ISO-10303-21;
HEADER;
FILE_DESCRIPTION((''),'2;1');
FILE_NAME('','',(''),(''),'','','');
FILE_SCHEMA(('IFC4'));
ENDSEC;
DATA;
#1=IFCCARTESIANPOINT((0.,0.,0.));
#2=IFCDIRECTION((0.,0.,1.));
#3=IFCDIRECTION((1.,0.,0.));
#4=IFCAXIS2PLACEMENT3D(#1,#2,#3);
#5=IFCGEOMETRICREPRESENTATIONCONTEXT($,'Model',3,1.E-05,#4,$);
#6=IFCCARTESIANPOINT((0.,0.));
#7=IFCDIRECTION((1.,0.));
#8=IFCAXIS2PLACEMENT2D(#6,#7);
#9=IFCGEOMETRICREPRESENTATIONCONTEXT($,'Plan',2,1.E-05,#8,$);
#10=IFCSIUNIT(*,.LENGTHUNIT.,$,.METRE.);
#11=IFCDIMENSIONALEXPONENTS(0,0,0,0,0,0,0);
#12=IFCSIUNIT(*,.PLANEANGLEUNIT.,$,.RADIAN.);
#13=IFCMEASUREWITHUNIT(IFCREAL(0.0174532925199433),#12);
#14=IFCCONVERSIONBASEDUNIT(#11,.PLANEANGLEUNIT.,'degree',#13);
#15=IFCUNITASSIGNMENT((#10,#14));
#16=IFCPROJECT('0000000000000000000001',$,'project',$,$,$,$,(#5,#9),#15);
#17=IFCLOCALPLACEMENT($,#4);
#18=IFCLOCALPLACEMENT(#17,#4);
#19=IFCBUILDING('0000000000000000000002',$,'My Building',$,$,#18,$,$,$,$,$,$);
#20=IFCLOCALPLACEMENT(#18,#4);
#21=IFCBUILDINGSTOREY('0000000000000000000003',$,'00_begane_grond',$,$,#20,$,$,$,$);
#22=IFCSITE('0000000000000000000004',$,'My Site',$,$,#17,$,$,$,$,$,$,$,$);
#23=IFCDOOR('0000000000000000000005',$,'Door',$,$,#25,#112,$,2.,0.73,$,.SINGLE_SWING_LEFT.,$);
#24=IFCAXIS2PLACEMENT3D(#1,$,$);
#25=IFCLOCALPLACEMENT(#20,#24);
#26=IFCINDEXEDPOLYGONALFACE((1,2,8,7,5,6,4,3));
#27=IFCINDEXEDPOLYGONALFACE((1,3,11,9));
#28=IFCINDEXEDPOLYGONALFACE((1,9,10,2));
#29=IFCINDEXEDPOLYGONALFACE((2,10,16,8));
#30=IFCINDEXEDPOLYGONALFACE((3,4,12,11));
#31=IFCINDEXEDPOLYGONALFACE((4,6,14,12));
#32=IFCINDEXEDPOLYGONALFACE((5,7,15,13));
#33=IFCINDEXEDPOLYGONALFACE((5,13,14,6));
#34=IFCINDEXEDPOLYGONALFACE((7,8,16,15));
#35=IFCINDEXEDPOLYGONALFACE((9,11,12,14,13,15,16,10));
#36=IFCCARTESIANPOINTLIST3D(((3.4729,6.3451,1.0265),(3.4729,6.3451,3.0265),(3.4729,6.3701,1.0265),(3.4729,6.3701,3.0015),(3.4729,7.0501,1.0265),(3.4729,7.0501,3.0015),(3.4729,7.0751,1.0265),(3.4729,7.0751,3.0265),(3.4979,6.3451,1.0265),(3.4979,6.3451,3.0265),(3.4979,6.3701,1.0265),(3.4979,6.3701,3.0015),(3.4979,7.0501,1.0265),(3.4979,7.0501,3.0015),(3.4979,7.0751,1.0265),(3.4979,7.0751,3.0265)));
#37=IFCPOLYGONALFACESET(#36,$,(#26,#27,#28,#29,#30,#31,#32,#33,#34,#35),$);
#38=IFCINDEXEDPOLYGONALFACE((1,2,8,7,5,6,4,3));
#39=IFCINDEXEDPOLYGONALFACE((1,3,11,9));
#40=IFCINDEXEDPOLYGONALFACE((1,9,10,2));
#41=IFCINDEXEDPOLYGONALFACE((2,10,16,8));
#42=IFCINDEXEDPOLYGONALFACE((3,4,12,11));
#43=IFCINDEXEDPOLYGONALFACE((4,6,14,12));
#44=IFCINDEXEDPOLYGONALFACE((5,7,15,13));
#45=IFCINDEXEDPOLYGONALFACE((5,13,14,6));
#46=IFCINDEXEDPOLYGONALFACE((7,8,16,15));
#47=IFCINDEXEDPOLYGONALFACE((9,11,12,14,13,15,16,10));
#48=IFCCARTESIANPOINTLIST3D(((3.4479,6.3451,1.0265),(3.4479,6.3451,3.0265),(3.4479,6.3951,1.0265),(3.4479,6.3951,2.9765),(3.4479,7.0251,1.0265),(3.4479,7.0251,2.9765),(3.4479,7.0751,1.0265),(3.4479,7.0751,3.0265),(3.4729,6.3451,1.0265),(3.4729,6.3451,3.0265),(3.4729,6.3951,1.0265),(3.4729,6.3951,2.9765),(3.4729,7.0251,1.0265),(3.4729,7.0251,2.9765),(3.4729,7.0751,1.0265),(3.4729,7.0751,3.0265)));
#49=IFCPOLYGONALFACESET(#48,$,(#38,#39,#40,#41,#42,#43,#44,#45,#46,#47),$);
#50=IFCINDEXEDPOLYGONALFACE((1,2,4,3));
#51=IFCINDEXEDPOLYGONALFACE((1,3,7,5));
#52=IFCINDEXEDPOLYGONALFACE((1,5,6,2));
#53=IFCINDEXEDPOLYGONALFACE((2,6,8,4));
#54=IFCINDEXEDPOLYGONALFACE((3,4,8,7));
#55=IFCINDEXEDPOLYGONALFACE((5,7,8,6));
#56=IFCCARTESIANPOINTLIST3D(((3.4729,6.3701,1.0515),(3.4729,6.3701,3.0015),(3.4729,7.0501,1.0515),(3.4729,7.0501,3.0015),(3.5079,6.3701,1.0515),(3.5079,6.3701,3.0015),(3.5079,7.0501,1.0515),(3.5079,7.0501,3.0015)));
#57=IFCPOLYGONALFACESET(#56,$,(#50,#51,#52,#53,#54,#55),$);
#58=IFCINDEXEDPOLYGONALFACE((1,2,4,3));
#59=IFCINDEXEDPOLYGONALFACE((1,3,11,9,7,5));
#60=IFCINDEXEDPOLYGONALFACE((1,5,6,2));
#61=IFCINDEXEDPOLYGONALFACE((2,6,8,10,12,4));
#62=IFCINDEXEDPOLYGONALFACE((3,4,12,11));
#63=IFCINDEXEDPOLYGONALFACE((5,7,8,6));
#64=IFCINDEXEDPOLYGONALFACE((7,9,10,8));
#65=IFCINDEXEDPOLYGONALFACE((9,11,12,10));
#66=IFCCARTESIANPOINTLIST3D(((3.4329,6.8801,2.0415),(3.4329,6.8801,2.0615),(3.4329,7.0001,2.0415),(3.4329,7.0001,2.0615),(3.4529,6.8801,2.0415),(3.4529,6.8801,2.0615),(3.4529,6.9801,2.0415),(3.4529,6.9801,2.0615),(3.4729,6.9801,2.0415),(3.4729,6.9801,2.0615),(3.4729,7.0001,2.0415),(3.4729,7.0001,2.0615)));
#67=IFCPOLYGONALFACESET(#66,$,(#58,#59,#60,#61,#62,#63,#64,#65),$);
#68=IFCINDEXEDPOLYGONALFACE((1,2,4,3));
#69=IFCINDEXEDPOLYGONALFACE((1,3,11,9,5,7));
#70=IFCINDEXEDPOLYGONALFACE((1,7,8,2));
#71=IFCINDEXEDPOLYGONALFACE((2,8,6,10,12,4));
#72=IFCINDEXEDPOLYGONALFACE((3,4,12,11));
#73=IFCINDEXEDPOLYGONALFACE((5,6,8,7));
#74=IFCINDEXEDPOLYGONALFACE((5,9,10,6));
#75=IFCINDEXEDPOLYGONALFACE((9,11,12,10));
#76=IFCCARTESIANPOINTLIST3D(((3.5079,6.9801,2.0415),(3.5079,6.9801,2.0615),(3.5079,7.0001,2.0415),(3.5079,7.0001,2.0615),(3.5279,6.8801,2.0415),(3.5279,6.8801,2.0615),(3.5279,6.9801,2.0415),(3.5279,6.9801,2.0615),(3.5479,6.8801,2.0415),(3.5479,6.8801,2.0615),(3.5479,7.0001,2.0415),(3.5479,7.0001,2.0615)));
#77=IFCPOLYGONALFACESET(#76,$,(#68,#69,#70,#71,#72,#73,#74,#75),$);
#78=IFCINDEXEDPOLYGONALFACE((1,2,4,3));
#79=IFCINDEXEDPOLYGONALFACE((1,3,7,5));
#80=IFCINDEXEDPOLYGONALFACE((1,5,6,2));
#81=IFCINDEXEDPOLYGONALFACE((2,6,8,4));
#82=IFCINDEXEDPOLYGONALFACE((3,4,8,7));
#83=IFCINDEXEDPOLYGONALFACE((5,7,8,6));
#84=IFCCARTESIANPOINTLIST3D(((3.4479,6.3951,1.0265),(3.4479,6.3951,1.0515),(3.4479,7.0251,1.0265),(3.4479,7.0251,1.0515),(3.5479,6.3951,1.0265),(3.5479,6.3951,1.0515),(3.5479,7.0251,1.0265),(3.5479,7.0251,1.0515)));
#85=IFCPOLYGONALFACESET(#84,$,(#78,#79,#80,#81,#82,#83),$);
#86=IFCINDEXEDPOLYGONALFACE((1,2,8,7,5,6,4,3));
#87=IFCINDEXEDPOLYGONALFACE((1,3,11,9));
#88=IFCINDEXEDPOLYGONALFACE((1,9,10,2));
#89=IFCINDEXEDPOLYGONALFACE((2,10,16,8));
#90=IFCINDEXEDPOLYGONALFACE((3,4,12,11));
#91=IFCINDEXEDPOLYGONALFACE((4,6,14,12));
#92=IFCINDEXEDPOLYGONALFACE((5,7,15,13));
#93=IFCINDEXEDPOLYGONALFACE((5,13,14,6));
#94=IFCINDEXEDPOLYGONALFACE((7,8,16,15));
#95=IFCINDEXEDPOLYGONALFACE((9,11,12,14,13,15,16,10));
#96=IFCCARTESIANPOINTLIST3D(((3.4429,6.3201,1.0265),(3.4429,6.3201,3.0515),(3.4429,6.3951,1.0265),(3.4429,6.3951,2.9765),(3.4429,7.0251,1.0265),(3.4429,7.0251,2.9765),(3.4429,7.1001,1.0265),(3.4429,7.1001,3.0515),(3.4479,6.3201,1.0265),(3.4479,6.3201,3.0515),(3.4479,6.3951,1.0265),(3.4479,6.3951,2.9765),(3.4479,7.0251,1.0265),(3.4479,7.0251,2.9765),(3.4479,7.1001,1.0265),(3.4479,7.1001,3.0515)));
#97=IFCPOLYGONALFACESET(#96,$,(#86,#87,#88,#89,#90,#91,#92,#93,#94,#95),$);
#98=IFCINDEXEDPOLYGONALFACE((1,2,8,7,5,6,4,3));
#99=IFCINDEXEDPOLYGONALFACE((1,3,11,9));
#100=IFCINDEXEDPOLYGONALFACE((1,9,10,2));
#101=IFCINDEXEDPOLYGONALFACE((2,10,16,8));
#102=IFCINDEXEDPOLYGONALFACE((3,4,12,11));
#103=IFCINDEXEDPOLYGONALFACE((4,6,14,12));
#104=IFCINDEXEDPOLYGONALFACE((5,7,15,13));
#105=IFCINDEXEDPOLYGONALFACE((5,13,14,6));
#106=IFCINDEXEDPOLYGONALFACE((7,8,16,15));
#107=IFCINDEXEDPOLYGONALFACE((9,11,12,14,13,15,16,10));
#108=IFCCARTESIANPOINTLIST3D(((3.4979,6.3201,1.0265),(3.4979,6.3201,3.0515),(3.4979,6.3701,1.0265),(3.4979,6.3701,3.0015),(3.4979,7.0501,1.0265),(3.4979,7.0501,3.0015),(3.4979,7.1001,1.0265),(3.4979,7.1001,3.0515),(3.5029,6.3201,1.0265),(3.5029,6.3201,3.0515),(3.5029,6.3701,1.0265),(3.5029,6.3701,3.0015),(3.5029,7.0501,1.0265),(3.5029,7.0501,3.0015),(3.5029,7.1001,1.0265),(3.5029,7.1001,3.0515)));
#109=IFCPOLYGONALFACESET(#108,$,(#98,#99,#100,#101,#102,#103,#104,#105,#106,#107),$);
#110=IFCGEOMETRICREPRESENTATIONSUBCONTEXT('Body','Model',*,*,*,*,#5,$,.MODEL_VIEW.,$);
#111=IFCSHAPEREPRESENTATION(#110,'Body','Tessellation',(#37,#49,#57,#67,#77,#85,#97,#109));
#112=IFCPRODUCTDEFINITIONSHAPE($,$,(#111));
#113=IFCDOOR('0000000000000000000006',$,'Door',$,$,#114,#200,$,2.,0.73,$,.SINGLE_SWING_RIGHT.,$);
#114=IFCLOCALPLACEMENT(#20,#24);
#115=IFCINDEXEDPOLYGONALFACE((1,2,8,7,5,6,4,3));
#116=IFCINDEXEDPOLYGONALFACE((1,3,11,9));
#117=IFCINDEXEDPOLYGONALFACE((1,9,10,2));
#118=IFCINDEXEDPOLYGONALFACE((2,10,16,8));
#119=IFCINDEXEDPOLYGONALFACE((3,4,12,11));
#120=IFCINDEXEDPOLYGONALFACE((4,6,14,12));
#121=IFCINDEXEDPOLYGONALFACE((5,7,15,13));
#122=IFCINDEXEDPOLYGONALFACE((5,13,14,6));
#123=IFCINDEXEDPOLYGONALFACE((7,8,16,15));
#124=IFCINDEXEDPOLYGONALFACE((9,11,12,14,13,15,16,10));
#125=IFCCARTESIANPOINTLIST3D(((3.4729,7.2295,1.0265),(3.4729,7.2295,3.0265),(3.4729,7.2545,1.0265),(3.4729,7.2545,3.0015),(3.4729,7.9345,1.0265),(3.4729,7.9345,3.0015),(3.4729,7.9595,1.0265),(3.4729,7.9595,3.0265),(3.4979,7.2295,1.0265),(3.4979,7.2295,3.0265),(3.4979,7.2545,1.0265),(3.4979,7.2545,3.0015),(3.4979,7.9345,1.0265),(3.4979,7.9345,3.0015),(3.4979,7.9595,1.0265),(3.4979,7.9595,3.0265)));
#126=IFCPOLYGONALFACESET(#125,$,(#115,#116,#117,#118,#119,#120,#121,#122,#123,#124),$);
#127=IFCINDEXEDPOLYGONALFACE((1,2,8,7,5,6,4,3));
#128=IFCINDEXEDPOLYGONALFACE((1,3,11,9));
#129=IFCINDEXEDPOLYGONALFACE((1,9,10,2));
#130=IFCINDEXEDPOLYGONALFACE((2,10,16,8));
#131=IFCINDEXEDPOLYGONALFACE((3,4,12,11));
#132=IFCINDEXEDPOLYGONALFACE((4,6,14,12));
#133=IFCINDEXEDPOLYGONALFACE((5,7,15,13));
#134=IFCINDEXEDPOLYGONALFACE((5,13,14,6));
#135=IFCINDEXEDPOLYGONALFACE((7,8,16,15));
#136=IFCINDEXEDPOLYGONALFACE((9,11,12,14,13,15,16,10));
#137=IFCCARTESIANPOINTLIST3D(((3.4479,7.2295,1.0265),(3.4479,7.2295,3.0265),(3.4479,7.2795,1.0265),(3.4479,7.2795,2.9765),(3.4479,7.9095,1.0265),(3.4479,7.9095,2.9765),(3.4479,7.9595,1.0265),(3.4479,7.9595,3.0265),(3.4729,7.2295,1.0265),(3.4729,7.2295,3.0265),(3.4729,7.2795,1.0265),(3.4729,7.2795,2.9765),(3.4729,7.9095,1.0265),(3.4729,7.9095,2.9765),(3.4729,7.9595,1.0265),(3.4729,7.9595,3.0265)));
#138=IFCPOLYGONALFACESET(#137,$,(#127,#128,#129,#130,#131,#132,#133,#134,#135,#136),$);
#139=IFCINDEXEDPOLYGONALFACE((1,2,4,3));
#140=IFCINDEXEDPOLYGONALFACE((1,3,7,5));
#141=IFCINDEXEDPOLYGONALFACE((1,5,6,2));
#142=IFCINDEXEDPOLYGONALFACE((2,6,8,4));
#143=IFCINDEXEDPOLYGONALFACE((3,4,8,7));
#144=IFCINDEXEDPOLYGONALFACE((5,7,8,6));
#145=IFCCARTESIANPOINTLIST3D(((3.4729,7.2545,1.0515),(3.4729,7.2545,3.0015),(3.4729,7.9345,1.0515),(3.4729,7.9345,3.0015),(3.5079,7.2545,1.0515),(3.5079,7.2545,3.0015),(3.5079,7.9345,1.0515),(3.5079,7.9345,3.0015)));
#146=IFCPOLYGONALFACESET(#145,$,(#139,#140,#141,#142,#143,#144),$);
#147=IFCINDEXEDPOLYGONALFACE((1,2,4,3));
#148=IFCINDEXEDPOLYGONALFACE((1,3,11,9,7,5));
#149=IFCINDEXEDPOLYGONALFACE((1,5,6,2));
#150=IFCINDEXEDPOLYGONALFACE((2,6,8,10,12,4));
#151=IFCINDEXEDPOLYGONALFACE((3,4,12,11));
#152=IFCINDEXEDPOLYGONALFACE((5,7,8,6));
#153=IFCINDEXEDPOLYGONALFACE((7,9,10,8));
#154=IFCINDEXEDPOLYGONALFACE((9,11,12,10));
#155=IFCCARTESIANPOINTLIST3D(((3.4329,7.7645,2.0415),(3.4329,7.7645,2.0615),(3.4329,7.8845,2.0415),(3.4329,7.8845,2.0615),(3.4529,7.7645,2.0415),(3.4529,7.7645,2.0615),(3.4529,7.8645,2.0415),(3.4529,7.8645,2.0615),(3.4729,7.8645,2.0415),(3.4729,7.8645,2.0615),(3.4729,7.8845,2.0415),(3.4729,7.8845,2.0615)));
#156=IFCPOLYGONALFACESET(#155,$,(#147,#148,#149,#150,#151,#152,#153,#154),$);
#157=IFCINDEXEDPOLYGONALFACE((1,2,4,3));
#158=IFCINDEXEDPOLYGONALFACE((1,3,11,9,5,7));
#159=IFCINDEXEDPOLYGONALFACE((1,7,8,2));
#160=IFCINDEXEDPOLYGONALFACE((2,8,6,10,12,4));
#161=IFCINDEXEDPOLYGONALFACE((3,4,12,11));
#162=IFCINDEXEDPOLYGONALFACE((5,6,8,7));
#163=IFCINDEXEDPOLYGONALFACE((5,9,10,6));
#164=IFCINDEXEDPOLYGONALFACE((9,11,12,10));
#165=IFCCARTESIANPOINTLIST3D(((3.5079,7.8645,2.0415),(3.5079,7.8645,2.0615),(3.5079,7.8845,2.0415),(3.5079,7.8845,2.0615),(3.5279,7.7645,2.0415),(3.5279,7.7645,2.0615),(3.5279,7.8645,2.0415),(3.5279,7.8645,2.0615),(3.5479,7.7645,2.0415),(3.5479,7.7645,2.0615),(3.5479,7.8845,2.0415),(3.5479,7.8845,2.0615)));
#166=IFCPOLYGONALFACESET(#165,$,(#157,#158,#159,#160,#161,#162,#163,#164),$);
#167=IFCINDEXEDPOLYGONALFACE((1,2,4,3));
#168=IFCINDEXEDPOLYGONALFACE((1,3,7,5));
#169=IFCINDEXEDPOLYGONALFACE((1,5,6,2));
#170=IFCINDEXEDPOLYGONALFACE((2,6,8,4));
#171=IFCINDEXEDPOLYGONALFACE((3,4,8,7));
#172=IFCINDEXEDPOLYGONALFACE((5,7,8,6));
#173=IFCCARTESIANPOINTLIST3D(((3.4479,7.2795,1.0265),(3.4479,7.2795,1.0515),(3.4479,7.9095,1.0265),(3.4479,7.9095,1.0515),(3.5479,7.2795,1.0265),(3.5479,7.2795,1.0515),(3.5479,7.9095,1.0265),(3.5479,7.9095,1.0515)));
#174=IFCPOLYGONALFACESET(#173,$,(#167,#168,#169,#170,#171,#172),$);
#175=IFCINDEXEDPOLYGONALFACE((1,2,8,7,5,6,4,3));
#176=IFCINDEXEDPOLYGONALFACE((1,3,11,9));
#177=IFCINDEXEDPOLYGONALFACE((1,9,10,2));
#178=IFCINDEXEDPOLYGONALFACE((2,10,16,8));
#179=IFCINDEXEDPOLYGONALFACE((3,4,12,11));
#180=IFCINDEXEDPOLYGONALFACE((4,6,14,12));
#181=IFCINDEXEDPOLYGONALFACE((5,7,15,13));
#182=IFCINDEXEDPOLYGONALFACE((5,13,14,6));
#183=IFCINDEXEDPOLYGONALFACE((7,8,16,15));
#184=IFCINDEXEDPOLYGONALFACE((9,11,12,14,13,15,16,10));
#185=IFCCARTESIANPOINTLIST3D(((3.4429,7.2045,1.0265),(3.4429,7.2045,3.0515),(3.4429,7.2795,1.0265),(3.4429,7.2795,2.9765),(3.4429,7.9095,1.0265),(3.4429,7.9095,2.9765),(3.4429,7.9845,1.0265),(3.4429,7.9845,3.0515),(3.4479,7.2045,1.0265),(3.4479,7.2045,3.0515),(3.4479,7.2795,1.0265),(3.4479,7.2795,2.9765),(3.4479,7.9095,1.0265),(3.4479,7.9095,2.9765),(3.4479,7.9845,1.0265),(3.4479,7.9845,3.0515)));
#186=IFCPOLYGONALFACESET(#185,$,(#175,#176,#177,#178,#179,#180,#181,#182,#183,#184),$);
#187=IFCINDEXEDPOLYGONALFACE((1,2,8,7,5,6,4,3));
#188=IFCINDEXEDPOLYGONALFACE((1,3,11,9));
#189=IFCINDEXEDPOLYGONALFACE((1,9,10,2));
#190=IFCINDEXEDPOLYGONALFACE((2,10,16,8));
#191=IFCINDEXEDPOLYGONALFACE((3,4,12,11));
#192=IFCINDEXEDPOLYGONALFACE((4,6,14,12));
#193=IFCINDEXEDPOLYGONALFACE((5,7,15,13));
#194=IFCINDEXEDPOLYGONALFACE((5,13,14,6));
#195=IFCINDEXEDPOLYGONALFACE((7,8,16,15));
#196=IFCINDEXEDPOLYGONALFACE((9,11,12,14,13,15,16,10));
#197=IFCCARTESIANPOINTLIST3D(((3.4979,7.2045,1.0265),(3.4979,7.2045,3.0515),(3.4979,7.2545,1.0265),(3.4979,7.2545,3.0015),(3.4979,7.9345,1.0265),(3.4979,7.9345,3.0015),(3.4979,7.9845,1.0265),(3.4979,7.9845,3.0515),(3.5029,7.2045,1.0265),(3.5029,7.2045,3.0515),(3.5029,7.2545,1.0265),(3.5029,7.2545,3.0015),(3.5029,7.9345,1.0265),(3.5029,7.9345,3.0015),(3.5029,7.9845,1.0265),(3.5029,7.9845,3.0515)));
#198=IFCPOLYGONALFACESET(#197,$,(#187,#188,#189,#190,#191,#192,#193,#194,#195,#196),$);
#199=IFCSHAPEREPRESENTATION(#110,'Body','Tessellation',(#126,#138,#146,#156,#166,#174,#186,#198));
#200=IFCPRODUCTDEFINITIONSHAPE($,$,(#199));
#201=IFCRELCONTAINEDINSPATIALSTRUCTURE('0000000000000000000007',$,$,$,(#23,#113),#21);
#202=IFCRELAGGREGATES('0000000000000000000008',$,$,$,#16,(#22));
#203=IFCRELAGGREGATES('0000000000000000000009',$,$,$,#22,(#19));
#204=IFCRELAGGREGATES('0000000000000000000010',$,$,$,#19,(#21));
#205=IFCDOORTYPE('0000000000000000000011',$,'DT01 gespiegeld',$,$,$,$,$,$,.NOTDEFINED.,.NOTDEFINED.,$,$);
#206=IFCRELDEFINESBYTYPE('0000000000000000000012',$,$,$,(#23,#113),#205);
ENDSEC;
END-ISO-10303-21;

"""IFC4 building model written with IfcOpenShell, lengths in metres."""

from ifc_helpers import new_model, entity, si_unit, converted_unit, frame, origin_with_axes, origin_2d_with_axis, place, context, subcontext, project, spatial, line, indexed_curve, outline, extrude, shape, source, transform, mapped, type_object, type_shapes, element, save


model = new_model("IFC4")

# Units and contexts
model_context = context("Model", 3, precision=1e-05, world=origin_with_axes())
plan_context = context("Plan", 2, precision=1e-05, world=origin_2d_with_axis())
body_context_1 = subcontext(model_context, "Body", "Model", "MODEL_VIEW")
body_context_2 = subcontext(plan_context, "Body", "Plan", "PLAN_VIEW")
ifc_project = project(units=[si_unit("LENGTHUNIT", "METRE"), converted_unit("PLANEANGLEUNIT", "degree", entity("IfcReal", 0.0174532925199433), si_unit("PLANEANGLEUNIT", "RADIAN"), dimensions=[0, 0, 0, 0, 0, 0, 0])], contexts=[model_context, plan_context])

# Site, building, storey
site_placement = place(None, origin_with_axes())
site = spatial("IfcSite", under=ifc_project, at=site_placement, Name="My Site")
building_placement = place(site_placement, origin_with_axes())
building = spatial("IfcBuilding", under=site, at=building_placement, Name="My Building")
storey_placement = place(building_placement, origin_with_axes())
storey = spatial("IfcBuildingStorey", under=building, at=storey_placement, Name="00_begane_grond")

# Doors
door_type_1 = type_object("IfcDoorType", Name="DT01 gespiegeld", OperationType="NOTDEFINED", PredefinedType="NOTDEFINED")
shared_shape_1 = source(origin_with_axes(), body_context_1, "Body", "SweptSolid", [
    extrude(outline(indexed_curve([(0.0, 0.0), (0.0, 2.0), (0.73, 2.0), (0.73, 0.0), (0.705, 0.0), (0.705, 1.975), (0.025, 1.975), (0.025, 0.0)], segments=[line(1, 2, 3, 4, 5, 6, 7, 8, 1)])), frame((0.0, 0.025, 0.0), z_axis=(0.0, -1.0, 0.0), x_axis=(1.0, 0.0, 0.0)), (0.0, 0.0, -1.0), 0.025),
    extrude(outline(indexed_curve([(0.0, 0.0), (0.0, 2.0), (0.73, 2.0), (0.73, 0.0), (0.68, 0.0), (0.68, 1.95), (0.05, 1.95), (0.05, 0.0)], segments=[line(1, 2, 3, 4, 5, 6, 7, 8, 1)])), frame((0.0, 0.0, 0.0), z_axis=(0.0, -1.0, 0.0), x_axis=(1.0, 0.0, 0.0)), (0.0, 0.0, -1.0), 0.025),
    extrude(outline(indexed_curve([(0.0, 0.0), (0.68, 0.0), (0.68, 0.035), (0.0, 0.035)], segments=[line(1, 2, 3, 4, 1)])), frame((0.025, 0.025, 0.025), z_axis=(0.0, 0.0, 1.0), x_axis=(1.0, 0.0, 0.0)), (0.0, 0.0, 1.0), 1.95),
    extrude(outline(indexed_curve([(0.0, 0.0), (0.0, -0.04), (0.12, -0.04), (0.12, -0.02), (0.02, -0.02), (0.02, 0.0)], segments=[line(1, 2, 3, 4, 5, 6, 1)])), frame((0.075, 0.025, 1.015), z_axis=(0.0, 0.0, 1.0), x_axis=(1.0, 0.0, 0.0)), (0.0, 0.0, 1.0), 0.02),
    extrude(outline(indexed_curve([(0.0, 0.0), (0.0, 0.04), (0.12, 0.04), (0.12, 0.02), (0.02, 0.02), (0.02, 0.0)], segments=[line(1, 2, 3, 4, 5, 6, 1)])), frame((0.075, 0.06, 1.015), z_axis=(0.0, 0.0, 1.0), x_axis=(1.0, 0.0, 0.0)), (0.0, 0.0, 1.0), 0.02),
    extrude(outline(indexed_curve([(0.0, 0.0), (0.63, 0.0), (0.63, 0.1), (0.0, 0.1)], segments=[line(1, 2, 3, 4, 1)])), frame((0.05, 0.0, 0.0), z_axis=(0.0, 0.0, 1.0), x_axis=(1.0, 0.0, 0.0)), (0.0, 0.0, 1.0), 0.025),
    extrude(outline(indexed_curve([(0.0, 0.0), (0.0, 2.025), (0.78, 2.025), (0.78, 0.0), (0.705, 0.0), (0.705, 1.95), (0.075, 1.95), (0.075, 0.0)], segments=[line(1, 2, 3, 4, 5, 6, 7, 8, 1)])), frame((-0.025, -0.005, 0.0), z_axis=(0.0, -1.0, 0.0), x_axis=(1.0, 0.0, 0.0)), (0.0, 0.0, -1.0), 0.005),
    extrude(outline(indexed_curve([(0.0, 0.0), (0.0, 2.025), (0.78, 2.025), (0.78, 0.0), (0.73, 0.0), (0.73, 1.975), (0.05, 1.975), (0.05, 0.0)], segments=[line(1, 2, 3, 4, 5, 6, 7, 8, 1)])), frame((-0.025, 0.05, 0.0), z_axis=(0.0, -1.0, 0.0), x_axis=(1.0, 0.0, 0.0)), (0.0, 0.0, -1.0), 0.005),
])
shared_shape_2 = source(origin_with_axes(), body_context_2, "Body", "Curve2D", [
    entity("IfcIndexedPolyCurve", entity("IfcCartesianPointList2D", [[0.0, 0.0], [0.0, 0.05], [0.025, 0.05], [0.025, 0.025], [0.05, 0.025], [0.05, 0.0]]), [entity("IfcLineIndex", [1, 2, 3, 4, 5, 6, 1])]),
    entity("IfcIndexedPolyCurve", entity("IfcCartesianPointList2D", [[0.73, 0.0], [0.73, 0.05], [0.705, 0.05], [0.705, 0.025], [0.68, 0.025], [0.68, 0.0]]), [entity("IfcLineIndex", [1, 2, 3, 4, 5, 6, 1])]),
    entity("IfcTrimmedCurve", entity("IfcEllipse", entity("IfcAxis2Placement2D", entity("IfcCartesianPoint", [0.67, 0.05]), entity("IfcDirection", [1.0, 0.0])), 0.645, 0.68), [entity("IfcCartesianPoint", [0.67, 0.73])], [entity("IfcCartesianPoint", [0.025, 0.05])], True, "CARTESIAN"),
    entity("IfcIndexedPolyCurve", entity("IfcCartesianPointList2D", [[0.705, 0.05], [0.67, 0.05], [0.67, 0.73], [0.705, 0.73]]), [entity("IfcLineIndex", [1, 2, 3, 4, 1])]),
])
type_shapes(door_type_1, [shared_shape_1, shared_shape_2])
placement_1 = place(storey_placement, frame((3.5329, 6.1759, 1.0265), z_axis=(0.0, 0.0, 1.0), x_axis=(0.000001, 1.0, 0.0)))
placement_2 = place(placement_1, frame((0.1692, 0.0, 0.0), z_axis=(0.0, 0.0, 1.0), x_axis=(1.0, 0.0, 0.0)))
door_1_placement = place(placement_2, frame((0.73, 0.085, 0.0), z_axis=(0.0, 0.0, 1.0), x_axis=(-1.0, 0.0, 0.0)))
element("IfcDoor", 1, at=door_1_placement, inside=storey, type_object=door_type_1, Name="Door", OperationType="SINGLE_SWING_LEFT", OverallHeight=2.0, OverallWidth=0.73, shapes=[
    shape(body_context_1, "Body", "MappedRepresentation", [mapped(shared_shape_1, transform((0.0, 0.0, 0.0), x_axis=(1.0, 0.0, 0.0), y_axis=(0.0, 1.0, 0.0), z_axis=(0.0, 0.0, 1.0), scale=1.0))]),
    shape(body_context_2, "Body", "MappedRepresentation", [mapped(shared_shape_2, transform((0.0, 0.0, 0.0), x_axis=(1.0, 0.0, 0.0), y_axis=(0.0, 1.0, 0.0), z_axis=(0.0, 0.0, 1.0), scale=1.0))]),
])
placement_3 = place(placement_1, frame((1.0537, 0.0, 0.0), z_axis=(0.0, 0.0, 1.0), x_axis=(1.0, 0.0, 0.0)))
door_2_placement = place(placement_3, frame((0.73, 0.085, 0.0), z_axis=(0.0, 0.0, 1.0), x_axis=(-1.0, 0.0, 0.0)))
element("IfcDoor", 2, at=door_2_placement, inside=storey, type_object=door_type_1, Name="Door", OperationType="SINGLE_SWING_RIGHT", OverallHeight=2.0, OverallWidth=0.73, shapes=[
    shape(body_context_1, "Body", "MappedRepresentation", [mapped(shared_shape_1, transform((0.0, 0.0, 0.0), x_axis=(1.0, 0.0, 0.0), y_axis=(0.0, 1.0, 0.0), z_axis=(0.0, 0.0, 1.0), scale=1.0))]),
    shape(body_context_2, "Body", "MappedRepresentation", [mapped(shared_shape_2, transform((0.0, 0.0, 0.0), x_axis=(1.0, 0.0, 0.0), y_axis=(0.0, 1.0, 0.0), z_axis=(0.0, 0.0, 1.0), scale=1.0))]),
])

save(model, "model.ifc")
